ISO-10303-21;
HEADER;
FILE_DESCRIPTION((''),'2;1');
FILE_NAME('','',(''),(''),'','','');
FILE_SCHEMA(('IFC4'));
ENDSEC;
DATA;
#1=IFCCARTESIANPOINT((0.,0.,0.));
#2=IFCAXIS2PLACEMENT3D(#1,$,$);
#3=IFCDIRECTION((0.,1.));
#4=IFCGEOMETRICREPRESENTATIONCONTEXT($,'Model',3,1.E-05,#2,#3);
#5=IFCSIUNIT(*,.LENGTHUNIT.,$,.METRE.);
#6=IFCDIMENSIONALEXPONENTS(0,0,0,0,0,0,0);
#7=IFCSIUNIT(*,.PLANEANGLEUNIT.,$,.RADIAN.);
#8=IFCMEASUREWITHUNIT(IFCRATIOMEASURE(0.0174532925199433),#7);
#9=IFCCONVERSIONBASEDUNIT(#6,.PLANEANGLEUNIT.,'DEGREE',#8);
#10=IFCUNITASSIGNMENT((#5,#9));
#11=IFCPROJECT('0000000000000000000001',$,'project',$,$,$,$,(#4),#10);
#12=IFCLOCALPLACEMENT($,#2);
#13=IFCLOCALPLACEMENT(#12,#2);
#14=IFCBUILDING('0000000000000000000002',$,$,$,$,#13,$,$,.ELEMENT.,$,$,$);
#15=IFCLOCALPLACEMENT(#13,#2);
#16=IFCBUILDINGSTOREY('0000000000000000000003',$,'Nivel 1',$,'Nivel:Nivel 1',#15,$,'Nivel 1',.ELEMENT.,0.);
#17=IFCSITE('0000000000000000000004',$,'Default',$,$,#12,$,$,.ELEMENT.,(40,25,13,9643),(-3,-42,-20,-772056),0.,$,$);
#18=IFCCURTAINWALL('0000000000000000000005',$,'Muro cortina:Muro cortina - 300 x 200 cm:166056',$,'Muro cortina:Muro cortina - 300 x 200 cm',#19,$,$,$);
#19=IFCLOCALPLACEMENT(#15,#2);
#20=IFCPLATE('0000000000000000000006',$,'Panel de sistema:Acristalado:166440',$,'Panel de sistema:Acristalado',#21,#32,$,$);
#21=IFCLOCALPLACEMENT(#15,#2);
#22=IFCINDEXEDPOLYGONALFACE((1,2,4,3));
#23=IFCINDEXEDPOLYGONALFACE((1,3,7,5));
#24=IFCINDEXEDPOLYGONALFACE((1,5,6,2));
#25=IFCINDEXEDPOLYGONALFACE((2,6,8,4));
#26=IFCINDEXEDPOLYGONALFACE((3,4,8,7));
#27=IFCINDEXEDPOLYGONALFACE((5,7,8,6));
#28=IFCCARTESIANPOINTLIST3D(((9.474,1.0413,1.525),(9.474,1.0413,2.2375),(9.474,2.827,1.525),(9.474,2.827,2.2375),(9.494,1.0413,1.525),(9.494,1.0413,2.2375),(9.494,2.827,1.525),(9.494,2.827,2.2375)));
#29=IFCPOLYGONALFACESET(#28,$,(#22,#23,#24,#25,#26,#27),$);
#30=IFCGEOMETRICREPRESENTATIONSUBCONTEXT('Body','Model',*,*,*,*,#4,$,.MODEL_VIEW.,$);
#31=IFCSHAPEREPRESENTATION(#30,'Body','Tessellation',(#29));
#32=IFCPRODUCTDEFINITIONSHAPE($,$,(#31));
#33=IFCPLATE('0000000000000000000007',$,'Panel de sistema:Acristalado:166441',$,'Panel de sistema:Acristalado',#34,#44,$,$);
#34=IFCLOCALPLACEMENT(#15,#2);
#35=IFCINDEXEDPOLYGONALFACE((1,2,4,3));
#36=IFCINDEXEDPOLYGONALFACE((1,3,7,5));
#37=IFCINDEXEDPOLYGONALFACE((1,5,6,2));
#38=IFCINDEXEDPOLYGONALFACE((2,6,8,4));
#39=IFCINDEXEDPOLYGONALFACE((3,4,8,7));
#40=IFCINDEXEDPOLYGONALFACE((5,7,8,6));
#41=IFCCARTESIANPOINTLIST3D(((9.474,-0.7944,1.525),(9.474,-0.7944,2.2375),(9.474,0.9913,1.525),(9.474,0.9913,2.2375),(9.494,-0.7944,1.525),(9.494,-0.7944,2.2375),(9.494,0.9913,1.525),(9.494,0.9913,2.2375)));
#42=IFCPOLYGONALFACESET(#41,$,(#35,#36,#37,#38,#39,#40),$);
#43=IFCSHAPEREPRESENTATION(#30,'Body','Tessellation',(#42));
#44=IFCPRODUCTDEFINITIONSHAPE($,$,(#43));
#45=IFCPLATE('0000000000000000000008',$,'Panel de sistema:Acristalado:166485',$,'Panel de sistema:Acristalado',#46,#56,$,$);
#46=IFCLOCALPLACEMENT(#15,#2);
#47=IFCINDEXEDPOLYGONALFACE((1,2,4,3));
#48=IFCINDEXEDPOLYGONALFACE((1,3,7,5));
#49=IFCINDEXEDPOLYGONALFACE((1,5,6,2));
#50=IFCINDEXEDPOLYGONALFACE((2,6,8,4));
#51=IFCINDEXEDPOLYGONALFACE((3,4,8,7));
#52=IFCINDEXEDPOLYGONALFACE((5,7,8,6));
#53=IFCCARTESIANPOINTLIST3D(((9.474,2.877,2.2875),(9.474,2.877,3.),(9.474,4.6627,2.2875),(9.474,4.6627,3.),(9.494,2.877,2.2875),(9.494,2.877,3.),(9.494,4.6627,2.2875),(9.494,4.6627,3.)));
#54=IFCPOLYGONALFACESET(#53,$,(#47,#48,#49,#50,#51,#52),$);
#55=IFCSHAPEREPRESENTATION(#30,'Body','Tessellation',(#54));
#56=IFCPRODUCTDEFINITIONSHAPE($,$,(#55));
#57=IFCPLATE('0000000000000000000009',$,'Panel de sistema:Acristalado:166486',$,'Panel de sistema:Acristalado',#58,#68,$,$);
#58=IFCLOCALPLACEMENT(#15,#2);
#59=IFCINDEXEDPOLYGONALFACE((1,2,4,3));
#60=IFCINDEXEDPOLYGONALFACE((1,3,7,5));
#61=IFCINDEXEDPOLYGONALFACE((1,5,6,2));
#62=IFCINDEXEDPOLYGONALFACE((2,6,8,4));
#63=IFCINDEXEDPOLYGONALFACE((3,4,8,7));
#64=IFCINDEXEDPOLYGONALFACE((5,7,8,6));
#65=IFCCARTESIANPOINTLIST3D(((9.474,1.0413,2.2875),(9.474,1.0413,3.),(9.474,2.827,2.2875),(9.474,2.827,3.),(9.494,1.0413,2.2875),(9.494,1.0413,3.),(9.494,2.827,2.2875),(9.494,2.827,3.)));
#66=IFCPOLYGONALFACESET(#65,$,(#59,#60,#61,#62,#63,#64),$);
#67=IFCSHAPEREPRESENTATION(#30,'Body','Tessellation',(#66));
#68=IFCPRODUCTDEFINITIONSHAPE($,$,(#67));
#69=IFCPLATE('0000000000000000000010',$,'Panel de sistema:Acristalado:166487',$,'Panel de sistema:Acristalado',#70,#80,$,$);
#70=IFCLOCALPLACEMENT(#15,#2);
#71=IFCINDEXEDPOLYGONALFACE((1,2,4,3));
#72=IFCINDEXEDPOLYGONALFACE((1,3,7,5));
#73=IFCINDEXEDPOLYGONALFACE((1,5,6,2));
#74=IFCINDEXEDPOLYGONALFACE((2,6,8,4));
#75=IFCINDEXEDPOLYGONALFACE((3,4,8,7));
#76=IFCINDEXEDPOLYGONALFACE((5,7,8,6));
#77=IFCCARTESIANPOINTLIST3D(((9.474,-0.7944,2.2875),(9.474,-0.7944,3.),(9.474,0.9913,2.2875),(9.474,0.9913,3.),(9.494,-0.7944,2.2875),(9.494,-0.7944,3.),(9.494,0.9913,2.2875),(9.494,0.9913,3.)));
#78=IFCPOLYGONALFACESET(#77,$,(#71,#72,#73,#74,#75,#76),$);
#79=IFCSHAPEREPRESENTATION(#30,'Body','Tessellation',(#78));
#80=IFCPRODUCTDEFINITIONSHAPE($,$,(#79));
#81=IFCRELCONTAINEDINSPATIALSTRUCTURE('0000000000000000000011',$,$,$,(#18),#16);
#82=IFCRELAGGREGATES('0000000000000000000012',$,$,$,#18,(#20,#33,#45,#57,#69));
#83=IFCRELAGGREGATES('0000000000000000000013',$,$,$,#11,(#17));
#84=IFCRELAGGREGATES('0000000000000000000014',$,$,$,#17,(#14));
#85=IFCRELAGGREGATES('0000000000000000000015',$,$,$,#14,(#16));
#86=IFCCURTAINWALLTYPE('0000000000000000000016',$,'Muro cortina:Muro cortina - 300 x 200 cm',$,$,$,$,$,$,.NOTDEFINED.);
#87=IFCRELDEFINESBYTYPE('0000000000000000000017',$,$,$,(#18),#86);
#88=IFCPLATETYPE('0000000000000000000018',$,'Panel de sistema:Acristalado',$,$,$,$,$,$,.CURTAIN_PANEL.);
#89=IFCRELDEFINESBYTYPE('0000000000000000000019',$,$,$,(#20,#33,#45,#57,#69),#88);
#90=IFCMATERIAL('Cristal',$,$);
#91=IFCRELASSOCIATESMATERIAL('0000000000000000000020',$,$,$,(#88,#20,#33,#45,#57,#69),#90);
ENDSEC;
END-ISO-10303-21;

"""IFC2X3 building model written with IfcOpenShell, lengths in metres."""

from ifc_helpers import new_model, entity, si_unit, converted_unit, direction, frame, origin, origin_2d_with_axis, place, context, subcontext, project, spatial, rectangle, extrude, source, transform, mapped, material, type_object, type_shapes, element, aggregate, save


model = new_model("IFC2X3")

# Units and contexts
model_context = context("Model", 3, precision=1e-05, world=origin(), true_north=direction((0.0, 1.0)))
body_context = subcontext(model_context, "Body", "Model", "MODEL_VIEW")
ifc_project = project(units=[si_unit("LENGTHUNIT", "METRE"), converted_unit("PLANEANGLEUNIT", "DEGREE", entity("IfcRatioMeasure", 0.0174532925199433), si_unit("PLANEANGLEUNIT", "RADIAN"), dimensions=[0, 0, 0, 0, 0, 0, 0])], contexts=[model_context])

# Site, building, storey
site_placement = place(None, origin())
site = spatial("IfcSite", under=ifc_project, at=site_placement, Name="Default", CompositionType="ELEMENT", RefLatitude=(40, 25, 13, 9643), RefLongitude=(-3, -42, -20, -772056), RefElevation=0.0)
building_placement = place(site_placement, origin())
building = spatial("IfcBuilding", under=site, at=building_placement, CompositionType="ELEMENT")
storey_placement = place(building_placement, origin())
storey = spatial("IfcBuildingStorey", under=building, at=storey_placement, Name="Nivel 1", ObjectType="Nivel:Nivel 1", LongName="Nivel 1", CompositionType="ELEMENT", Elevation=0.0)

# Curtain wall, plates
curtain_wall_type = type_object("IfcCurtainWallType", Name="Muro cortina:Muro cortina - 300 x 200 cm", PredefinedType="NOTDEFINED")
curtain_wall_placement = place(storey_placement, origin())
curtain_wall = element("IfcCurtainWall", 1, at=curtain_wall_placement, inside=storey, type_object=curtain_wall_type, Name="Muro cortina:Muro cortina - 300 x 200 cm:166056", ObjectType="Muro cortina:Muro cortina - 300 x 200 cm")
ifc_material_1 = material(Name="Cristal")
plate_type = type_object("IfcPlateType", Name="Panel de sistema:Acristalado", PredefinedType="CURTAIN_PANEL", material=ifc_material_1)
shared_shape_1 = source(origin(), body_context, "Body", "SweptSolid", [
    extrude(rectangle(XDim=0.02, YDim=1.7857, at=origin_2d_with_axis()), frame((0.0, 0.0, 0.0), z_axis=(0.0, 0.0, 1.0), x_axis=(0.0, 1.0, 0.0)), (0.0, 0.0, 1.0), 0.7125),
])
type_shapes(plate_type, [shared_shape_1])
plate_1_placement = place(curtain_wall_placement, frame((9.484, 1.9342, 1.525), z_axis=(0.0, 0.0, 1.0), x_axis=(0.0, -1.0, 0.0)))
plate_1 = element("IfcPlate", 2, at=plate_1_placement, type_object=plate_type, material=ifc_material_1, Name="Panel de sistema:Acristalado:166440", ObjectType="Panel de sistema:Acristalado", context=body_context, shape_type="MappedRepresentation", body=[
    mapped(shared_shape_1, transform((0.0, 0.0, 0.0), scale=1.0)),
])
plate_2_placement = place(curtain_wall_placement, frame((9.484, 0.0985, 1.525), z_axis=(0.0, 0.0, 1.0), x_axis=(0.0, -1.0, 0.0)))
plate_2 = element("IfcPlate", 3, at=plate_2_placement, type_object=plate_type, material=ifc_material_1, Name="Panel de sistema:Acristalado:166441", ObjectType="Panel de sistema:Acristalado", context=body_context, shape_type="MappedRepresentation", body=[
    mapped(shared_shape_1, transform((0.0, 0.0, 0.0), scale=1.0)),
])
plate_3_placement = place(curtain_wall_placement, frame((9.484, 3.7699, 2.2875), z_axis=(0.0, 0.0, 1.0), x_axis=(0.0, -1.0, 0.0)))
plate_3 = element("IfcPlate", 4, at=plate_3_placement, type_object=plate_type, material=ifc_material_1, Name="Panel de sistema:Acristalado:166485", ObjectType="Panel de sistema:Acristalado", context=body_context, shape_type="MappedRepresentation", body=[
    mapped(shared_shape_1, transform((0.0, 0.0, 0.0), scale=1.0)),
])
plate_4_placement = place(curtain_wall_placement, frame((9.484, 1.9342, 2.2875), z_axis=(0.0, 0.0, 1.0), x_axis=(0.0, -1.0, 0.0)))
plate_4 = element("IfcPlate", 5, at=plate_4_placement, type_object=plate_type, material=ifc_material_1, Name="Panel de sistema:Acristalado:166486", ObjectType="Panel de sistema:Acristalado", context=body_context, shape_type="MappedRepresentation", body=[
    mapped(shared_shape_1, transform((0.0, 0.0, 0.0), scale=1.0)),
])
plate_5_placement = place(curtain_wall_placement, frame((9.484, 0.0985, 2.2875), z_axis=(0.0, 0.0, 1.0), x_axis=(0.0, -1.0, 0.0)))
plate_5 = element("IfcPlate", 6, at=plate_5_placement, type_object=plate_type, material=ifc_material_1, Name="Panel de sistema:Acristalado:166487", ObjectType="Panel de sistema:Acristalado", context=body_context, shape_type="MappedRepresentation", body=[
    mapped(shared_shape_1, transform((0.0, 0.0, 0.0), scale=1.0)),
])
aggregate(curtain_wall, [plate_1, plate_2, plate_3, plate_4, plate_5])

save(model, "model.ifc")
